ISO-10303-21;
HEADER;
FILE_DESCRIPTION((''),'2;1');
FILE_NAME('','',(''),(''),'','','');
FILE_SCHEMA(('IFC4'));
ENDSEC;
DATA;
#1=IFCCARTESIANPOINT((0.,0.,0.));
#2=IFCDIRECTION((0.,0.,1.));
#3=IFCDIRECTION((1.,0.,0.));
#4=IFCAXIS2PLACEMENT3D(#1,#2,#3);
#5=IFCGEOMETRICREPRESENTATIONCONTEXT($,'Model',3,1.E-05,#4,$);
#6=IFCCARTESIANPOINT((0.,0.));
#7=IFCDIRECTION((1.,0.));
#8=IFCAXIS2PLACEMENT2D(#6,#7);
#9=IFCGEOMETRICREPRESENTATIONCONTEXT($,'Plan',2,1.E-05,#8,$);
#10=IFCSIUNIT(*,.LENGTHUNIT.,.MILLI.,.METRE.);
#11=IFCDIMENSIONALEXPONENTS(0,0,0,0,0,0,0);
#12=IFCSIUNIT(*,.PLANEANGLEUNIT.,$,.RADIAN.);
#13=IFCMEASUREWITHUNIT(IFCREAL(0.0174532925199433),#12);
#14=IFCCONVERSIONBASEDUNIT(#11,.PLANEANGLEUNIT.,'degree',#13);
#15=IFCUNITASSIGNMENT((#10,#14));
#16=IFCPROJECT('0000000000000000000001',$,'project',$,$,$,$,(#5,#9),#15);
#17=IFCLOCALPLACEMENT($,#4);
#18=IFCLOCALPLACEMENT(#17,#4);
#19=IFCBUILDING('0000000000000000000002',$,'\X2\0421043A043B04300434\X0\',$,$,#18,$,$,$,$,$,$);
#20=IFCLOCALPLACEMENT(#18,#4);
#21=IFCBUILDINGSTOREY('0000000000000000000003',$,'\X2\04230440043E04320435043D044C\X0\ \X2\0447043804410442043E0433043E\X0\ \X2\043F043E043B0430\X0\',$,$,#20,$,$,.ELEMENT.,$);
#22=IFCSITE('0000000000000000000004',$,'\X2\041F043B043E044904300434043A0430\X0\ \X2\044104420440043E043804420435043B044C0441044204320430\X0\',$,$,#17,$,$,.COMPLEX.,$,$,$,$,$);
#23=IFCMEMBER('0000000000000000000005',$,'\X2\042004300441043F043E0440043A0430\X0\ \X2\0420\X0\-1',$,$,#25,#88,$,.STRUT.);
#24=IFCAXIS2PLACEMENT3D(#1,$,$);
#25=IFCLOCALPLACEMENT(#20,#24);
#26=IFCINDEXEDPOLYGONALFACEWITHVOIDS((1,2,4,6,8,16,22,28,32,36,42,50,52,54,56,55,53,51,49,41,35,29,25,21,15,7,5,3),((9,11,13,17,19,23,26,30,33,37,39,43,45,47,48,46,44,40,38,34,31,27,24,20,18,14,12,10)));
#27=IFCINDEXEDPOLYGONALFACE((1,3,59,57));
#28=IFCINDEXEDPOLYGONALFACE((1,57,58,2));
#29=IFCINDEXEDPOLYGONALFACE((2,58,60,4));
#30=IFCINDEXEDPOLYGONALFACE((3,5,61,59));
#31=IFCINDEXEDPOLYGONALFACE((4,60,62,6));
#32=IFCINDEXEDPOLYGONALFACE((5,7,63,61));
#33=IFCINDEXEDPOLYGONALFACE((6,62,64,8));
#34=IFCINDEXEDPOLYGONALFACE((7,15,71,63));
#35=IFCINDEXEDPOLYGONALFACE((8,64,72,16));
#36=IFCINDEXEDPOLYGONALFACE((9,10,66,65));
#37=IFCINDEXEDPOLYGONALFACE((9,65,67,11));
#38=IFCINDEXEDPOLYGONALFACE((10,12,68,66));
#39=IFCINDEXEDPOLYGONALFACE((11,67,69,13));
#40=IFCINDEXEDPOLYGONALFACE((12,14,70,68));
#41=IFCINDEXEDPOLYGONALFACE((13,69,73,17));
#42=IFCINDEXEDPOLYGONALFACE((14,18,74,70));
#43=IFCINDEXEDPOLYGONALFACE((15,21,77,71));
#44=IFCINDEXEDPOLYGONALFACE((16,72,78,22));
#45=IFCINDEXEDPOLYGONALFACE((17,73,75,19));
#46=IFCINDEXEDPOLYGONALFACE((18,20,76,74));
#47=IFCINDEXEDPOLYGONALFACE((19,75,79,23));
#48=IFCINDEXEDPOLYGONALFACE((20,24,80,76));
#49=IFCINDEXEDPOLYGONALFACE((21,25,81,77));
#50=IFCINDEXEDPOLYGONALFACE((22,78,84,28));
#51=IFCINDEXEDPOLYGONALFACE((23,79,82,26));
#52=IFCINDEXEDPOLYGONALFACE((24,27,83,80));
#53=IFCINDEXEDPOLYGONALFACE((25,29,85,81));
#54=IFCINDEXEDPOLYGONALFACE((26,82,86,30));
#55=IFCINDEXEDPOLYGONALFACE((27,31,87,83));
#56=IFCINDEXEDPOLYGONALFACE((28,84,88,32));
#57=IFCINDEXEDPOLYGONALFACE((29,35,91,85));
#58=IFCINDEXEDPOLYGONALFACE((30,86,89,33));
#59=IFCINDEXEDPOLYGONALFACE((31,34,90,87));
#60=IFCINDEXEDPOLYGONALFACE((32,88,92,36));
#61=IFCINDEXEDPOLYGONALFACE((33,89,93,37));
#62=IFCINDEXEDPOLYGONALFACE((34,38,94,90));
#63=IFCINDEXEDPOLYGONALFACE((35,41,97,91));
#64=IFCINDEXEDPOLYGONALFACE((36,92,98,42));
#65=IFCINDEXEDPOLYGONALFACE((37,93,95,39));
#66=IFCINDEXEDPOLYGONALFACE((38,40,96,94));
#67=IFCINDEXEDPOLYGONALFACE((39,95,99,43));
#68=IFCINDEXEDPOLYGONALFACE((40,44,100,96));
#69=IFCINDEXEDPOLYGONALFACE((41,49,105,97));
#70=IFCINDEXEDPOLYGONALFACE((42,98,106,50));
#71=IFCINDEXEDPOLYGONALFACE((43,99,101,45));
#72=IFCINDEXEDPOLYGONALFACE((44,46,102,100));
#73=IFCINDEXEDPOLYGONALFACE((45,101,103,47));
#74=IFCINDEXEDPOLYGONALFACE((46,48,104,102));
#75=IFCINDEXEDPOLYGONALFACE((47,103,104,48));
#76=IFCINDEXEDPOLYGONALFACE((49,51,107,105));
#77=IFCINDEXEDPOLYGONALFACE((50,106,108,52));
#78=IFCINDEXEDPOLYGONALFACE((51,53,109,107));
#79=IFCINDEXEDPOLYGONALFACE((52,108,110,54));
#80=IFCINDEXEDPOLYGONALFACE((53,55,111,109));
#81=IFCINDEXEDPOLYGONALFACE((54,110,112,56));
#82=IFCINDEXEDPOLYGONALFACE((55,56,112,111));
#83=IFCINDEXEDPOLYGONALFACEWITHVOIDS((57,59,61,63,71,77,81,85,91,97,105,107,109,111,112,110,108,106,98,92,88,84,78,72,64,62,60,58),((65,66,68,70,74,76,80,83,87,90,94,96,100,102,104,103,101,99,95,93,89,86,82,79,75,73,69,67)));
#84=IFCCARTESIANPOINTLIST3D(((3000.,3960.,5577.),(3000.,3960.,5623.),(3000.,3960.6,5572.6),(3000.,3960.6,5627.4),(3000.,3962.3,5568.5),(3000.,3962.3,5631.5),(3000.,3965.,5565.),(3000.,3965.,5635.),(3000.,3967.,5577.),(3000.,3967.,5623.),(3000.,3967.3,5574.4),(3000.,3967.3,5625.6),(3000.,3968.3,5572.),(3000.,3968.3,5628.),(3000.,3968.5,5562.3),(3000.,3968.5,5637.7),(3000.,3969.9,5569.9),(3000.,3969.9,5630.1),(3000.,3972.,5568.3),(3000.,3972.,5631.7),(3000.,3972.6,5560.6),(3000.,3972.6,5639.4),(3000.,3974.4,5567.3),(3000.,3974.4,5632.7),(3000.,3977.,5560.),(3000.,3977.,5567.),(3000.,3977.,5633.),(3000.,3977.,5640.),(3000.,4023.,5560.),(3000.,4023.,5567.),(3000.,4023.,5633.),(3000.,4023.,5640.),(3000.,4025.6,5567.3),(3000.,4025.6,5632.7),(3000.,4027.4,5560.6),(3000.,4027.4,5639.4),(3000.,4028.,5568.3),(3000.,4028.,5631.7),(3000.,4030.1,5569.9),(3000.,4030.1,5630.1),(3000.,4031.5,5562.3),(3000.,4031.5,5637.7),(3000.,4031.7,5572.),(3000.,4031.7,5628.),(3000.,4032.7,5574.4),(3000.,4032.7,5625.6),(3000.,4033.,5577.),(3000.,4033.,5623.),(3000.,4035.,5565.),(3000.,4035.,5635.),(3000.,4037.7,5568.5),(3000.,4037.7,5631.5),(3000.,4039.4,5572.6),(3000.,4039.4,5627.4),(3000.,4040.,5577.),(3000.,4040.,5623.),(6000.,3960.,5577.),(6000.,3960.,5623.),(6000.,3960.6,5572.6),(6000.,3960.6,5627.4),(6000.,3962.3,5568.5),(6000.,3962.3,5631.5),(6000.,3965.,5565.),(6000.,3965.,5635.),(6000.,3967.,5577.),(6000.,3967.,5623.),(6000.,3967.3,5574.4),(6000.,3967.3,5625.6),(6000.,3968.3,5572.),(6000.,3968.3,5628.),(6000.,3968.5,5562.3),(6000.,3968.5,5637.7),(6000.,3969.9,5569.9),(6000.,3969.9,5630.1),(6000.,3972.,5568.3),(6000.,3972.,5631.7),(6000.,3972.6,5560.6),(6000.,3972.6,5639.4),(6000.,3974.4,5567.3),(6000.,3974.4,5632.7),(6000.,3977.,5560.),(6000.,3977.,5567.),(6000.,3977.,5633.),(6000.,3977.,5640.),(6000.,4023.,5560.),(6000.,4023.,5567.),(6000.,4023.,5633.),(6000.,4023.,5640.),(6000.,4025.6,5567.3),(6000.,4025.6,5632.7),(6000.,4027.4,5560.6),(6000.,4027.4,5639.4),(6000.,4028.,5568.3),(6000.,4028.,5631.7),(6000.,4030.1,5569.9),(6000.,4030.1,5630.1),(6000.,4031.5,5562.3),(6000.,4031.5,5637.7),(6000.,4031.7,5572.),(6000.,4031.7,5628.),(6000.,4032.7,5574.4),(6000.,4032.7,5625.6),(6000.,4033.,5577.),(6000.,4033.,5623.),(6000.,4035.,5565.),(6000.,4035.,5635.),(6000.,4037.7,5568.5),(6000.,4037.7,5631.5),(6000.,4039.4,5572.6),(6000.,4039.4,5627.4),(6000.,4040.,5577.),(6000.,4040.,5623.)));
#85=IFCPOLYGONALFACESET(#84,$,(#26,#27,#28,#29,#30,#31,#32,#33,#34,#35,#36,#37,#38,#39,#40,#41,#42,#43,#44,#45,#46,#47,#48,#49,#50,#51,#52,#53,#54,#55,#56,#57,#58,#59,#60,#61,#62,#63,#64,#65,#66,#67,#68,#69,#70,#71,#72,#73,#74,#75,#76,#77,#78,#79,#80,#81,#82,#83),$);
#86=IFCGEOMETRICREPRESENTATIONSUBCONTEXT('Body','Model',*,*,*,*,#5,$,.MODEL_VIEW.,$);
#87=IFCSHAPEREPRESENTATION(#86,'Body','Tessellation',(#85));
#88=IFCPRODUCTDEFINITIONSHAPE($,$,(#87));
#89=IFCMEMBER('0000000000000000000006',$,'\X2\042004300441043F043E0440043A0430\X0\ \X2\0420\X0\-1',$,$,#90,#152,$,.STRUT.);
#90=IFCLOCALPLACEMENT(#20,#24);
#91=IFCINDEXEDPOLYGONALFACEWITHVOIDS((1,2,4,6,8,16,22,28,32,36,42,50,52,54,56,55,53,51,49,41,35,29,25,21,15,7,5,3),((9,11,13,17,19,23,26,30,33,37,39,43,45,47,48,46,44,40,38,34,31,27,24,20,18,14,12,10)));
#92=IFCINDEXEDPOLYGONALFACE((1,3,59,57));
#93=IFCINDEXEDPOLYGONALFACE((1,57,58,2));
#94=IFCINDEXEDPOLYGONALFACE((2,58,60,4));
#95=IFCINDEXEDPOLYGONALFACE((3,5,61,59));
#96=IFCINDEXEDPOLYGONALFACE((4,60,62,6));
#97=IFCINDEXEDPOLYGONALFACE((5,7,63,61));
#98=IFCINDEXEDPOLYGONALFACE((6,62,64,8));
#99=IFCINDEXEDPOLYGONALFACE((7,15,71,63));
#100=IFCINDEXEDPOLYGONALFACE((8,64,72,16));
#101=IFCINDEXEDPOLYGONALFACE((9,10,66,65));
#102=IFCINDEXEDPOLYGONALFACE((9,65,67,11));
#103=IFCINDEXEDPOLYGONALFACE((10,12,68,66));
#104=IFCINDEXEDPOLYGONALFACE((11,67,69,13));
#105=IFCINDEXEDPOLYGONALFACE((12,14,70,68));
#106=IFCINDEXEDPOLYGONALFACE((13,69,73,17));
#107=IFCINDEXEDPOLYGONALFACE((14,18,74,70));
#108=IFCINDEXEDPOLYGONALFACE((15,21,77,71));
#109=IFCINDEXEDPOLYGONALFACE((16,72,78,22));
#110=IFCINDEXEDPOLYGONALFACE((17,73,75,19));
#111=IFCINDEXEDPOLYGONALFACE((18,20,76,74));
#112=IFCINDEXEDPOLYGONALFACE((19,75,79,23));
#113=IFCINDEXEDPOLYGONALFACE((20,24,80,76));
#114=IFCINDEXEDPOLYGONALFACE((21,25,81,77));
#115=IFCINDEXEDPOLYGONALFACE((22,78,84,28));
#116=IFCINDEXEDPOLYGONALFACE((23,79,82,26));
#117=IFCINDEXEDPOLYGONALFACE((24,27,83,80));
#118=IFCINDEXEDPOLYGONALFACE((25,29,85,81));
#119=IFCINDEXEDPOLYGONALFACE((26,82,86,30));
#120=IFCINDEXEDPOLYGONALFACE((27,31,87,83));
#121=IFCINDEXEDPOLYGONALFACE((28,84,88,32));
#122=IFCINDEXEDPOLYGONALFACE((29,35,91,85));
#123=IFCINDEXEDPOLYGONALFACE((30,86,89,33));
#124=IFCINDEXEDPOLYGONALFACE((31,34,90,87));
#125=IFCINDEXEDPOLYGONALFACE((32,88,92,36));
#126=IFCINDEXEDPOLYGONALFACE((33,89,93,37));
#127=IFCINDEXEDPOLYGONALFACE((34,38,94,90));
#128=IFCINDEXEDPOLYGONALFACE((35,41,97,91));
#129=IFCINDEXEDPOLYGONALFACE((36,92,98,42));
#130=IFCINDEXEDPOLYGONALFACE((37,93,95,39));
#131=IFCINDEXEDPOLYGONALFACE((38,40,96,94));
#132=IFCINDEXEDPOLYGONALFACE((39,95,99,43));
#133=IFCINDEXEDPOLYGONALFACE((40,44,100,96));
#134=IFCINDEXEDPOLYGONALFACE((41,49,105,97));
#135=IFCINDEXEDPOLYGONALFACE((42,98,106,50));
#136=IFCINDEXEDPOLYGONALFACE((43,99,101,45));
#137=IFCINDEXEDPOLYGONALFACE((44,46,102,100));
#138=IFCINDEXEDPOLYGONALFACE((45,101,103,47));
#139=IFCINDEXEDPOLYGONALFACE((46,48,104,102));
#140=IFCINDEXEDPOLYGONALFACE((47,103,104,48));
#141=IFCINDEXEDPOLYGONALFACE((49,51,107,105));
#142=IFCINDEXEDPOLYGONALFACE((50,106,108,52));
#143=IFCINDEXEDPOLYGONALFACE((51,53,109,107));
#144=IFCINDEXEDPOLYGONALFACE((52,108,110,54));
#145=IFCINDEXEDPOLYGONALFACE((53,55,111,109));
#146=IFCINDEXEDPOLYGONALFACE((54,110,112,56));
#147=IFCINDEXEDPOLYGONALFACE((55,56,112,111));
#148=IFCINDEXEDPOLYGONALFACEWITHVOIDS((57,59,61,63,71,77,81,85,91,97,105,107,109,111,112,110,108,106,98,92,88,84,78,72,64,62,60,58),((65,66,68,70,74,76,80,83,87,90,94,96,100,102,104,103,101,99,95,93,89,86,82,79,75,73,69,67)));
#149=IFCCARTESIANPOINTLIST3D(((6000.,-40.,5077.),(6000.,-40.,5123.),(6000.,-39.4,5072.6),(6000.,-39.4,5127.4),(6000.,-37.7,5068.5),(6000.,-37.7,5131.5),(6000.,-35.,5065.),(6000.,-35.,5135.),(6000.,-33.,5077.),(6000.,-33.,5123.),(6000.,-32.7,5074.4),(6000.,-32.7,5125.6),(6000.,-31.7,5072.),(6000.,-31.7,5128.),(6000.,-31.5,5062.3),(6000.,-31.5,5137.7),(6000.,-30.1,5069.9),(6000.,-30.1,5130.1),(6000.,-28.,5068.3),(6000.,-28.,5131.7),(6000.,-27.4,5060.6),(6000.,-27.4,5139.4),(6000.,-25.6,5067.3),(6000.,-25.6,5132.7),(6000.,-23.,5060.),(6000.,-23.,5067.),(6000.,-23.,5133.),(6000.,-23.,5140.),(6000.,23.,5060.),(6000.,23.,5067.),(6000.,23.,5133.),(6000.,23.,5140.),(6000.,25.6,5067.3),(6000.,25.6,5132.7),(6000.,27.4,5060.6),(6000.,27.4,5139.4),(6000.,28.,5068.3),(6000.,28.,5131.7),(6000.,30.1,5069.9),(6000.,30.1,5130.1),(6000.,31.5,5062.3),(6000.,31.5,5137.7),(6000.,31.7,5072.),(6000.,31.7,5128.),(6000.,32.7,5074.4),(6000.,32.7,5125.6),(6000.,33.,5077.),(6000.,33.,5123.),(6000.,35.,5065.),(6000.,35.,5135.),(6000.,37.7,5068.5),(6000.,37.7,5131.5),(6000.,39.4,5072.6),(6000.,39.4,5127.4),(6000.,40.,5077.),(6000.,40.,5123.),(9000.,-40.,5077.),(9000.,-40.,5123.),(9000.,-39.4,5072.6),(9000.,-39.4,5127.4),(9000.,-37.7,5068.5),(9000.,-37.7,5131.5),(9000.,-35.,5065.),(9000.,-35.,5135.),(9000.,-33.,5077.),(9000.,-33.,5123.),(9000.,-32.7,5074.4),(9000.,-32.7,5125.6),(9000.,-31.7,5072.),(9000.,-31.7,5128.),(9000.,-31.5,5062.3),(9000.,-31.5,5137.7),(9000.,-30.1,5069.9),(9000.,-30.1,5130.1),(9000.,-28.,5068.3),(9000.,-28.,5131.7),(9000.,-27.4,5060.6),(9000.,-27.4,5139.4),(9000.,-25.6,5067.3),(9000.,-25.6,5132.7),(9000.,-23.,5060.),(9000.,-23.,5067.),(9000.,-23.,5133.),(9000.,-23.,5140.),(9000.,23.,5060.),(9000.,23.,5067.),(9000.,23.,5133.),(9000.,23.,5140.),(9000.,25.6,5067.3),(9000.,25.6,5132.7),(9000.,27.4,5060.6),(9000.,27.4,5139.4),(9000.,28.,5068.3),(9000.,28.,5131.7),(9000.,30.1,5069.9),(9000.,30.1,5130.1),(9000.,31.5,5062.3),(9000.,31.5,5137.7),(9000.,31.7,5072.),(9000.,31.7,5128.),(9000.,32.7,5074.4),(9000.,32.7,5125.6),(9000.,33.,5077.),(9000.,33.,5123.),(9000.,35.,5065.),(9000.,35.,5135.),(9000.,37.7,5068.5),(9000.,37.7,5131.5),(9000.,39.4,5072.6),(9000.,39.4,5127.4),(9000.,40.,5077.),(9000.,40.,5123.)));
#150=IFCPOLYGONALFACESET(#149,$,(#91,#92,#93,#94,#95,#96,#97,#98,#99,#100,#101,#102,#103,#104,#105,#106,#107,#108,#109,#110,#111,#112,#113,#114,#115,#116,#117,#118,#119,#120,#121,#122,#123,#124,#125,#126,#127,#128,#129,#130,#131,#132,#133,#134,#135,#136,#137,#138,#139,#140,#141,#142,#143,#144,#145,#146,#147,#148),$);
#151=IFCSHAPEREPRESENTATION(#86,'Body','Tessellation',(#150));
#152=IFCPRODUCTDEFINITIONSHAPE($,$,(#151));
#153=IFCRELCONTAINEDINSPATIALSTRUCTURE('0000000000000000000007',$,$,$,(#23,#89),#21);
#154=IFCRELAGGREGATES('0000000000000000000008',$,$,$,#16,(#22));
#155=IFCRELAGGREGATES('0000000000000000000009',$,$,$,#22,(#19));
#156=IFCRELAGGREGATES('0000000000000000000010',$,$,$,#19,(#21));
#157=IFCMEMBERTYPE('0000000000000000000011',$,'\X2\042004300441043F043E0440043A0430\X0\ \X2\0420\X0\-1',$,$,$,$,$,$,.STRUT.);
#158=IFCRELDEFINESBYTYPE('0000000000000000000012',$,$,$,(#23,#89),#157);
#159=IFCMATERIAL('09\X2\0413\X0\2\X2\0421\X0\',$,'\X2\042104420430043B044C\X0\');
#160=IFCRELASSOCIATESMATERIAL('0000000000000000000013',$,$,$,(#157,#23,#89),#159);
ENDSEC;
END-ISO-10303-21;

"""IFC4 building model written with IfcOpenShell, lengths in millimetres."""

from ifc_helpers import new_model, entity, si_unit, converted_unit, frame, origin_with_axes, origin_2d_with_axis, place, context, subcontext, project, spatial, hollow_rectangle, extrude, material, material_profile, profile_set, profile_usage, type_object, element, save


model = new_model("IFC4")

# Units and contexts
model_context = context("Model", 3, precision=1e-05, world=origin_with_axes())
plan_context = context("Plan", 2, precision=1e-05, world=origin_2d_with_axis())
body_context = subcontext(model_context, "Body", "Model", "MODEL_VIEW")
ifc_project = project(units=[si_unit("LENGTHUNIT", "METRE", prefix="MILLI"), converted_unit("PLANEANGLEUNIT", "degree", entity("IfcReal", 0.0174532925199433), si_unit("PLANEANGLEUNIT", "RADIAN"), dimensions=[0, 0, 0, 0, 0, 0, 0])], contexts=[model_context, plan_context])

# Site, building, storey
site_placement = place(None, origin_with_axes())
site = spatial("IfcSite", under=ifc_project, at=site_placement, Name="Площадка строительства", CompositionType="COMPLEX")
building_placement = place(site_placement, origin_with_axes())
building = spatial("IfcBuilding", under=site, at=building_placement, Name="Склад")
storey_placement = place(building_placement, origin_with_axes())
storey = spatial("IfcBuildingStorey", under=building, at=storey_placement, Name="Уровень чистого пола", CompositionType="ELEMENT")

# Members
ifc_material_1 = material(Name="09Г2С", Category="Сталь")
ifc_material_profile_1 = material_profile(ifc_material_1, hollow_rectangle(XDim=80.0, YDim=80.0, WallThickness=7.0, InnerFilletRadius=10.0, OuterFilletRadius=17.0))
ifc_profile_set_1 = profile_set([ifc_material_profile_1], Name="PK80x7_09G2S")
member_type_1 = type_object("IfcMemberType", Name="Распорка Р-1", PredefinedType="STRUT", material=ifc_profile_set_1)
ifc_profile_usage_1 = profile_usage(ifc_profile_set_1, cardinal=5)
member_1_placement = place(storey_placement, frame((3000.0, 4000.0, 5600.0), z_axis=(1.0, 0.0, 0.0), x_axis=(0.0, 1.0, 0.0)))
element("IfcMember", 1, at=member_1_placement, inside=storey, type_object=member_type_1, material=ifc_profile_usage_1, Name="Распорка Р-1", PredefinedType="STRUT", context=body_context, shape_type="SweptSolid", body=[
    extrude(hollow_rectangle(XDim=80.0, YDim=80.0, WallThickness=7.0, InnerFilletRadius=10.0, OuterFilletRadius=17.0), origin_with_axes(), (0.0, 0.0, 1.0), 3000.0),
])
ifc_profile_usage_2 = profile_usage(ifc_profile_set_1, cardinal=5)
member_2_placement = place(storey_placement, frame((6000.0, 0.0, 5100.0), z_axis=(1.0, 0.0, 0.0), x_axis=(0.0, 1.0, 0.0)))
element("IfcMember", 2, at=member_2_placement, inside=storey, type_object=member_type_1, material=ifc_profile_usage_2, Name="Распорка Р-1", PredefinedType="STRUT", context=body_context, shape_type="SweptSolid", body=[
    extrude(hollow_rectangle(XDim=80.0, YDim=80.0, WallThickness=7.0, InnerFilletRadius=10.0, OuterFilletRadius=17.0), origin_with_axes(), (0.0, 0.0, 1.0), 3000.0),
])

save(model, "model.ifc")
